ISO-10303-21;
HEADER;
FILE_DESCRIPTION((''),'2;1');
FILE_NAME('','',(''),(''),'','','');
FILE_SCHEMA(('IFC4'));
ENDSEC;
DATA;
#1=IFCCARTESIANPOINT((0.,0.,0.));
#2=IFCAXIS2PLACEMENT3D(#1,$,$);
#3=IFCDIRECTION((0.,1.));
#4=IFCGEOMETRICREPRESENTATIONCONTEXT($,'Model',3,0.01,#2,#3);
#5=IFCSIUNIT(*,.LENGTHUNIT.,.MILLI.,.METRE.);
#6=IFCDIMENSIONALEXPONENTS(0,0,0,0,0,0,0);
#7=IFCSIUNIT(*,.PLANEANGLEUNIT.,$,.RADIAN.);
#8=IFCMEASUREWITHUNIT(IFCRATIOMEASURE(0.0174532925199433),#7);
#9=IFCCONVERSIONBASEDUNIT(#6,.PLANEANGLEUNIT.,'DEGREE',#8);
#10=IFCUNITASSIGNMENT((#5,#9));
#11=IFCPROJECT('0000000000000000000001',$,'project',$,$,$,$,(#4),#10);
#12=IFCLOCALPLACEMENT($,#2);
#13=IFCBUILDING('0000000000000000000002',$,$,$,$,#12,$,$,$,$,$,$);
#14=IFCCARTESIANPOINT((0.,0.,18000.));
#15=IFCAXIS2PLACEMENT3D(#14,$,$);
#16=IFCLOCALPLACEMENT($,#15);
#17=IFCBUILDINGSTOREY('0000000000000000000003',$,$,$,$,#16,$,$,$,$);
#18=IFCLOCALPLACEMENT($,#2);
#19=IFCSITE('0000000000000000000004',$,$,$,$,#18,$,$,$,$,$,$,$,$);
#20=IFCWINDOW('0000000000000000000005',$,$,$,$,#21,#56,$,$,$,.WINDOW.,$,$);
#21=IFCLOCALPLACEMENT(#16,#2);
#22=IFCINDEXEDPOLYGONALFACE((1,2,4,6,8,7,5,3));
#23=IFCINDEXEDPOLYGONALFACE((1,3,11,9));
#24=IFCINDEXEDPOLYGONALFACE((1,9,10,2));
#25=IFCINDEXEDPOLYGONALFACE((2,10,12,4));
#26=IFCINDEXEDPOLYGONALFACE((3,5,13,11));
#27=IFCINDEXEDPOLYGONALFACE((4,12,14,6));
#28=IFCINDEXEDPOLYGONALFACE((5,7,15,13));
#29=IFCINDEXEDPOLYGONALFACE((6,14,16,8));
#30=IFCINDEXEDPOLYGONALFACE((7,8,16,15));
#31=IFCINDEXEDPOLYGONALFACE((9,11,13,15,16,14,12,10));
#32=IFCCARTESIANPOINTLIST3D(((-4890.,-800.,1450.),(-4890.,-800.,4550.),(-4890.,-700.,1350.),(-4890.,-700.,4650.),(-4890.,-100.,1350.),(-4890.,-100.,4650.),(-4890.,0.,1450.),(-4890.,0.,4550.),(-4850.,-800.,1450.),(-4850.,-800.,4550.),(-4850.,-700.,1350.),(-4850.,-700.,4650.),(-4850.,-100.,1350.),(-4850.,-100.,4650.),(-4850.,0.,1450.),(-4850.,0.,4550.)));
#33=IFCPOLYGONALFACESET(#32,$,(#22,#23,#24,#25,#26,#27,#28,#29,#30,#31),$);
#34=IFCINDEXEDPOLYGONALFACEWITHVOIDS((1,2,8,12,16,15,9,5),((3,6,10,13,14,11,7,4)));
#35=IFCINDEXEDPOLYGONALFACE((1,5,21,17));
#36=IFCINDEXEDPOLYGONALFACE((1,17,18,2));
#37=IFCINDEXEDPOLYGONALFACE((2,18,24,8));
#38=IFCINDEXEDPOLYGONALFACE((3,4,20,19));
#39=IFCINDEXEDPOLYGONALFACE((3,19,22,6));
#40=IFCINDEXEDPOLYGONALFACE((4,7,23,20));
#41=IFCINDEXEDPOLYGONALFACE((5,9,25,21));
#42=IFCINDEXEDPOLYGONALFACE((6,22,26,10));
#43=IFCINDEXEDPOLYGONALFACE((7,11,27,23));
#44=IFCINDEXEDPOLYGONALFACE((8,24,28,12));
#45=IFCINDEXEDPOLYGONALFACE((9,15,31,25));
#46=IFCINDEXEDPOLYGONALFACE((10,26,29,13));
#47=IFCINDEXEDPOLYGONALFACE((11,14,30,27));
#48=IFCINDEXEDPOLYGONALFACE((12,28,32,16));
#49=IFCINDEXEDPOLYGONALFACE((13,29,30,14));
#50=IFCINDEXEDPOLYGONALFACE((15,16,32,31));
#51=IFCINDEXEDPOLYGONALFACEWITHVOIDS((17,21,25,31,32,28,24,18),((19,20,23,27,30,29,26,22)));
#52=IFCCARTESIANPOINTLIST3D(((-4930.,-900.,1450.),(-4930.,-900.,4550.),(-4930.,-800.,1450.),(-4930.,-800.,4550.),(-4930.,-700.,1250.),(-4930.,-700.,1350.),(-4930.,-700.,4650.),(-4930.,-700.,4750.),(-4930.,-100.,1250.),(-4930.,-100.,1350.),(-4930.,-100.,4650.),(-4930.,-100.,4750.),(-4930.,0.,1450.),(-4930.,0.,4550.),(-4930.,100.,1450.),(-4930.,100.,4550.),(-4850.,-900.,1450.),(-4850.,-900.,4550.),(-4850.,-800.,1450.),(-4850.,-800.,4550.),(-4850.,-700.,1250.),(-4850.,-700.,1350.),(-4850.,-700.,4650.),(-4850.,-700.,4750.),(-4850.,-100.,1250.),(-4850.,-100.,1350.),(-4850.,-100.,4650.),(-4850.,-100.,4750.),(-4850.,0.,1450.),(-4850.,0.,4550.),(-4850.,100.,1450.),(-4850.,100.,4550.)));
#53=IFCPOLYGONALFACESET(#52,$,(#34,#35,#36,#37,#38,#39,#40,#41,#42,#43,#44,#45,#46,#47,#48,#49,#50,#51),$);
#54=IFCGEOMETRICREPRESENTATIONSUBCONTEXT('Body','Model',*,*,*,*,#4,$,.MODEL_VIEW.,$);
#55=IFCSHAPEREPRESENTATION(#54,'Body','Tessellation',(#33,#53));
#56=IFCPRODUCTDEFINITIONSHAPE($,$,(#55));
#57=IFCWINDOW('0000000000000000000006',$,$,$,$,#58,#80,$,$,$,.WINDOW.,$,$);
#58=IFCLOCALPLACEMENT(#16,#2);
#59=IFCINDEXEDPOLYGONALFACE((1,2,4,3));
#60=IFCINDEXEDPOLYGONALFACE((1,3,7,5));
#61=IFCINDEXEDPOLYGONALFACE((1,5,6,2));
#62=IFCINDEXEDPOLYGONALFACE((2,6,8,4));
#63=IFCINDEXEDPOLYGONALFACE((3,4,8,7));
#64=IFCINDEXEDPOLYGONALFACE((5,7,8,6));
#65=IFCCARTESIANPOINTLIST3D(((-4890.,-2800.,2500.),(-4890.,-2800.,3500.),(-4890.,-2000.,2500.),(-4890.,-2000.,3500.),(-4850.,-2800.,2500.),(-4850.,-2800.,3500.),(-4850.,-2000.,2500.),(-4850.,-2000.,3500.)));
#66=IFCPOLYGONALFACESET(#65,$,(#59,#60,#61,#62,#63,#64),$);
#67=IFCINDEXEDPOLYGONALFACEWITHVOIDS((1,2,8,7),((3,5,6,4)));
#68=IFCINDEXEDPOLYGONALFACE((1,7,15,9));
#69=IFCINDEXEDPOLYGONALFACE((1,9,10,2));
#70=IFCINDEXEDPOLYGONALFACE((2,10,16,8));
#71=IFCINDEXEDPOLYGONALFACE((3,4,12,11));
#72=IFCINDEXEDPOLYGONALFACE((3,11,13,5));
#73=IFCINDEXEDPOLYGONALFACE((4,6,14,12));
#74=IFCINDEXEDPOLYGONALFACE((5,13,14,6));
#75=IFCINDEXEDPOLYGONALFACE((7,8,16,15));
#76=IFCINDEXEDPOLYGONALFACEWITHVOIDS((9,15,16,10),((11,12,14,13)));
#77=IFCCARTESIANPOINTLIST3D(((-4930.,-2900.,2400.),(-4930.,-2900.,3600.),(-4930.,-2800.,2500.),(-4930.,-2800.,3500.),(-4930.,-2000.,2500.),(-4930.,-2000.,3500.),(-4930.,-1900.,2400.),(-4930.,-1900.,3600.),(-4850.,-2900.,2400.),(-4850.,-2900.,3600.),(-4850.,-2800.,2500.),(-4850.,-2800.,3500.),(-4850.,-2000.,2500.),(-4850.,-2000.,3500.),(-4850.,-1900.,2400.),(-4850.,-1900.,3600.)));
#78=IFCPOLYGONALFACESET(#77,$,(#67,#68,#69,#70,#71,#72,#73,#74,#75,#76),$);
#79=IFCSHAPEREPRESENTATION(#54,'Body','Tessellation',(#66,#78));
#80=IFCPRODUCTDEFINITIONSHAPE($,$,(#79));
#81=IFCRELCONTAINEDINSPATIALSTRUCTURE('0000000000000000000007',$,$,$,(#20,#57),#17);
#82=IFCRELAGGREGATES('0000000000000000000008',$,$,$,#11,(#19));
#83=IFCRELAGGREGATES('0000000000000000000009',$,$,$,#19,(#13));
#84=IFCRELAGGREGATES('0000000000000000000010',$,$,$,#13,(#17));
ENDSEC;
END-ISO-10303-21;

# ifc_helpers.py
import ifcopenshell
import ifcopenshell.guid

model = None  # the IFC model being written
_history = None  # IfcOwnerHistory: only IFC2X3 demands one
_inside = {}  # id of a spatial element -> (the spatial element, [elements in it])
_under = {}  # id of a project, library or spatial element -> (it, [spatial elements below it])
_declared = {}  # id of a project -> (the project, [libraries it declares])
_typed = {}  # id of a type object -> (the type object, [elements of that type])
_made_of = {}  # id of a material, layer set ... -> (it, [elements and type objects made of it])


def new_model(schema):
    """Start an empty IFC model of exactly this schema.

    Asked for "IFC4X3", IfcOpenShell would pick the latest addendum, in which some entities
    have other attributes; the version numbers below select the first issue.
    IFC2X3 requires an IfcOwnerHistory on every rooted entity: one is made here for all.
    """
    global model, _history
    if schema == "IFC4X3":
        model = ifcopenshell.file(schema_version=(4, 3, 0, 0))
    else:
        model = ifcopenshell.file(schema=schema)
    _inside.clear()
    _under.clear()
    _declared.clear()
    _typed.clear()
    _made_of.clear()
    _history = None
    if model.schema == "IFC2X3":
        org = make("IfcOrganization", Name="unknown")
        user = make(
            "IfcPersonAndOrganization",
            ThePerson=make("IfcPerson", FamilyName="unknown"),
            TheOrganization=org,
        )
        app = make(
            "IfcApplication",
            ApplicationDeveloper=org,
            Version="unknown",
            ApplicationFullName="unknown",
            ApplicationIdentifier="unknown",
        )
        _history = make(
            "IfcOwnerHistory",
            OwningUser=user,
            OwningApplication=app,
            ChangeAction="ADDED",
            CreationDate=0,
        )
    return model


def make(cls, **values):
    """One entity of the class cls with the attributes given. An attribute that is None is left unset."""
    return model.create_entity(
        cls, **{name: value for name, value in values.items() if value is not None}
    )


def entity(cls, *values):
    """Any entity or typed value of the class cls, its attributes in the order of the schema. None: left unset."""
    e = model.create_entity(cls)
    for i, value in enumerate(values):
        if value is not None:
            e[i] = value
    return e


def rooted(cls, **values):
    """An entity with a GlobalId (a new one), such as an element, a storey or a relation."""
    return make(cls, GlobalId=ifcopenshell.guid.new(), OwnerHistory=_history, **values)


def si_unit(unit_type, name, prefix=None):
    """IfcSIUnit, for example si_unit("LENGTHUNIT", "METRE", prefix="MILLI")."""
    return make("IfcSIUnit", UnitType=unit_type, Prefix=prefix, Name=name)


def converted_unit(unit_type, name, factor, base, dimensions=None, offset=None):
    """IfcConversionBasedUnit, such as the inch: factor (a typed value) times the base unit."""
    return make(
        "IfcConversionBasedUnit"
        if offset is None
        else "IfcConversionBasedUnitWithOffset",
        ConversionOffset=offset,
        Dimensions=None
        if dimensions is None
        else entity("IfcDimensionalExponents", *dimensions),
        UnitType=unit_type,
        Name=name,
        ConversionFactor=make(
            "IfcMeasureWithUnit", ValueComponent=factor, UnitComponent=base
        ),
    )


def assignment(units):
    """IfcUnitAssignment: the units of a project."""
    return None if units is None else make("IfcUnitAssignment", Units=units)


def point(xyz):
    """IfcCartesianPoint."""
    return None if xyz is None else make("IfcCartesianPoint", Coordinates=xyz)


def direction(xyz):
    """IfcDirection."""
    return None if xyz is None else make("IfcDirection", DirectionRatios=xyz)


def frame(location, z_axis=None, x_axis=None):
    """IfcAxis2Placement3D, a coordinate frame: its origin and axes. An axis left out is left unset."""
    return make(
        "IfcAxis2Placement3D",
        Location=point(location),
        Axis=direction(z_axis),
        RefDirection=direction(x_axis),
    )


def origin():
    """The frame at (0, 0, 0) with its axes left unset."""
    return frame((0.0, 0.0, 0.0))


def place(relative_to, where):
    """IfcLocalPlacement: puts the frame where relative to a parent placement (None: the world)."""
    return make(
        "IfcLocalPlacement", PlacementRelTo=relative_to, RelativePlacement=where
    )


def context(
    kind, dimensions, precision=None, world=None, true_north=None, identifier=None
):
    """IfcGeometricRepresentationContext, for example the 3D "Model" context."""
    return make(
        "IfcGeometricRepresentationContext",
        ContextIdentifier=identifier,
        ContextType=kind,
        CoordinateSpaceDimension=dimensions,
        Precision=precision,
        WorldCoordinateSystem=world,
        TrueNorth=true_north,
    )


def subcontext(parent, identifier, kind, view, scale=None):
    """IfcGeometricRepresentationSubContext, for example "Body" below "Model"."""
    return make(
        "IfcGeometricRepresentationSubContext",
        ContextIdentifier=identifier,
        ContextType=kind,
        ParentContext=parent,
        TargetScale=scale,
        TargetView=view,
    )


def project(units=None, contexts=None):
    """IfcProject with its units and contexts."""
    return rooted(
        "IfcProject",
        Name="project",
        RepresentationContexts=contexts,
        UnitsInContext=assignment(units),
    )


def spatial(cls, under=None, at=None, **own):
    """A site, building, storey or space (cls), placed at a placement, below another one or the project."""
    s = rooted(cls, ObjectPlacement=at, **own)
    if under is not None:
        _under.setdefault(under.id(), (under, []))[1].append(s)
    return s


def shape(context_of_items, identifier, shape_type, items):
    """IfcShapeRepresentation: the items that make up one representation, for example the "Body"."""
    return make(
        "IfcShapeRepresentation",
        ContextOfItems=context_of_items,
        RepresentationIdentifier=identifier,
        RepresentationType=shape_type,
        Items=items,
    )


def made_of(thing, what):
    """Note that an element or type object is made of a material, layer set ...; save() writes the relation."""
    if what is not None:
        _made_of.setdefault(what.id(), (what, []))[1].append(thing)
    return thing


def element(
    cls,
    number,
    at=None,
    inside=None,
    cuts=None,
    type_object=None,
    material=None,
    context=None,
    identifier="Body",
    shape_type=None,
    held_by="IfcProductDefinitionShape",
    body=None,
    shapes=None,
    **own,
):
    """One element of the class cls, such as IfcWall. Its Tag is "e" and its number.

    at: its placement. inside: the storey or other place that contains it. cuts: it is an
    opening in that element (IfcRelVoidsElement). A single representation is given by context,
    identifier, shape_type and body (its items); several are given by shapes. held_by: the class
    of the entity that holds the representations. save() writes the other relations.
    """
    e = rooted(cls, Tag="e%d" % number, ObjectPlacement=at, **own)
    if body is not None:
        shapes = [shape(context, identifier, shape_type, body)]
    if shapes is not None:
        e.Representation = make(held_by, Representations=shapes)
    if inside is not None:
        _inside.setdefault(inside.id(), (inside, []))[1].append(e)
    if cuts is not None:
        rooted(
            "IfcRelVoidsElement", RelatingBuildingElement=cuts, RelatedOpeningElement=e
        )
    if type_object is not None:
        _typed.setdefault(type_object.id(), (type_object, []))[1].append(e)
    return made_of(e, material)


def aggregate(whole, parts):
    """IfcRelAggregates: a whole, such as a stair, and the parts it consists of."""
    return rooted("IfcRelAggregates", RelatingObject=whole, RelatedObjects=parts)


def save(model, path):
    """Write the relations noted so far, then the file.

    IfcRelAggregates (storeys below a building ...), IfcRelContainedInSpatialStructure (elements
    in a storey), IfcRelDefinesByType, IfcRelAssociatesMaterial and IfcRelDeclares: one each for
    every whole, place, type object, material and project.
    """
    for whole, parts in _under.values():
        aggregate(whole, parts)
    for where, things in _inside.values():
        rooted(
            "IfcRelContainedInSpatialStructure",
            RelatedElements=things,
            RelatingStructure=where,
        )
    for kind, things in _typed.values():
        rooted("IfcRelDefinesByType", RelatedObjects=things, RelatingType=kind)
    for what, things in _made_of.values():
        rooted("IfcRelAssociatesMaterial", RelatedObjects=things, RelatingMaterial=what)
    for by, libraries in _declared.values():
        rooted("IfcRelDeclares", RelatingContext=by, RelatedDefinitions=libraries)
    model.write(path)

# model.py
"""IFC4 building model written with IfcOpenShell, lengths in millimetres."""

from ifc_helpers import new_model, entity, si_unit, converted_unit, direction, frame, origin, place, context, subcontext, project, spatial, element, save


model = new_model("IFC4")

# Units and contexts
model_context = context("Model", 3, precision=0.01, world=origin(), true_north=direction((0.0, 1.0)))
body_context = subcontext(model_context, "Body", "Model", "MODEL_VIEW")
ifc_project = project(units=[si_unit("LENGTHUNIT", "METRE", prefix="MILLI"), converted_unit("PLANEANGLEUNIT", "DEGREE", entity("IfcRatioMeasure", 0.0174532925199433), si_unit("PLANEANGLEUNIT", "RADIAN"), dimensions=[0, 0, 0, 0, 0, 0, 0])], contexts=[model_context])

# Site, building, storey
site_placement = place(None, origin())
site = spatial("IfcSite", under=ifc_project, at=site_placement)
building_placement = place(None, origin())
building = spatial("IfcBuilding", under=site, at=building_placement)
storey_placement = place(None, frame((0.0, 0.0, 18000.0)))
storey = spatial("IfcBuildingStorey", under=building, at=storey_placement)

# Shared definitions
cartesian_point_1 = entity("IfcCartesianPoint", [-400.0, -1550.0])
shared_polyline_1 = entity("IfcPolyline", [cartesian_point_1, entity("IfcCartesianPoint", [-400.0, 1550.0]), entity("IfcCartesianPoint", [-300.0, 1650.0]), entity("IfcCartesianPoint", [300.0, 1650.0]), entity("IfcCartesianPoint", [400.0, 1550.0]), entity("IfcCartesianPoint", [400.0, -1550.0]), entity("IfcCartesianPoint", [300.0, -1650.0]), entity("IfcCartesianPoint", [-300.0, -1650.0]), cartesian_point_1])
cartesian_point_2 = entity("IfcCartesianPoint", [-400.0, -500.0])
shared_polyline_2 = entity("IfcPolyline", [cartesian_point_2, entity("IfcCartesianPoint", [-400.0, 500.0]), entity("IfcCartesianPoint", [-400.0, 500.0]), entity("IfcCartesianPoint", [400.0, 500.0]), entity("IfcCartesianPoint", [400.0, 500.0]), entity("IfcCartesianPoint", [400.0, -500.0]), entity("IfcCartesianPoint", [400.0, -500.0]), entity("IfcCartesianPoint", [-400.0, -500.0]), cartesian_point_2])

# Shared definitions
wall_1_placement = place(storey_placement, frame((-4900.0, 100.0, 0.0), z_axis=(0.0, 0.0, 1.0), x_axis=(0.0, -1.0, 0.0)))
window_1_placement = place(wall_1_placement, frame((500.0, 50.0, 3000.0)))
window_2_placement = place(wall_1_placement, frame((2500.0, 50.0, 3000.0)))

# Windows
cartesian_point_3 = entity("IfcCartesianPoint", [-500.0, -1550.0])
element("IfcWindow", 1, at=window_1_placement, inside=storey, PredefinedType="WINDOW", context=body_context, shape_type="SweptSolid", body=[
    entity("IfcExtrudedAreaSolid", entity("IfcArbitraryClosedProfileDef", "AREA", None, shared_polyline_1), entity("IfcAxis2Placement3D", entity("IfcCartesianPoint", [0.0, 0.0, 0.0]), entity("IfcDirection", [0.0, -1.0, 0.0]), entity("IfcDirection", [1.0, 0.0, 0.0])), entity("IfcDirection", [0.0, 0.0, 1.0]), 40.0),
    entity("IfcExtrudedAreaSolid", entity("IfcArbitraryProfileDefWithVoids", "AREA", None, entity("IfcPolyline", [cartesian_point_3, entity("IfcCartesianPoint", [-500.0, 1550.0]), entity("IfcCartesianPoint", [-300.0, 1750.0]), entity("IfcCartesianPoint", [300.0, 1750.0]), entity("IfcCartesianPoint", [500.0, 1550.0]), entity("IfcCartesianPoint", [500.0, -1550.0]), entity("IfcCartesianPoint", [300.0, -1750.0]), entity("IfcCartesianPoint", [-300.0, -1750.0]), cartesian_point_3]), [shared_polyline_1]), entity("IfcAxis2Placement3D", entity("IfcCartesianPoint", [0.0, 0.0, 0.0]), entity("IfcDirection", [0.0, -1.0, 0.0]), entity("IfcDirection", [1.0, 0.0, 0.0])), entity("IfcDirection", [0.0, 0.0, 1.0]), 80.0),
])
cartesian_point_4 = entity("IfcCartesianPoint", [-500.0, -600.0])
element("IfcWindow", 2, at=window_2_placement, inside=storey, PredefinedType="WINDOW", context=body_context, shape_type="SweptSolid", body=[
    entity("IfcExtrudedAreaSolid", entity("IfcArbitraryClosedProfileDef", "AREA", None, shared_polyline_2), entity("IfcAxis2Placement3D", entity("IfcCartesianPoint", [0.0, 0.0, 0.0]), entity("IfcDirection", [0.0, -1.0, 0.0]), entity("IfcDirection", [1.0, 0.0, 0.0])), entity("IfcDirection", [0.0, 0.0, 1.0]), 40.0),
    entity("IfcExtrudedAreaSolid", entity("IfcArbitraryProfileDefWithVoids", "AREA", None, entity("IfcPolyline", [cartesian_point_4, entity("IfcCartesianPoint", [-500.0, 600.0]), entity("IfcCartesianPoint", [-500.0, 600.0]), entity("IfcCartesianPoint", [500.0, 600.0]), entity("IfcCartesianPoint", [500.0, 600.0]), entity("IfcCartesianPoint", [500.0, -600.0]), entity("IfcCartesianPoint", [500.0, -600.0]), entity("IfcCartesianPoint", [-500.0, -600.0]), cartesian_point_4]), [shared_polyline_2]), entity("IfcAxis2Placement3D", entity("IfcCartesianPoint", [0.0, 0.0, 0.0]), entity("IfcDirection", [0.0, -1.0, 0.0]), entity("IfcDirection", [1.0, 0.0, 0.0])), entity("IfcDirection", [0.0, 0.0, 1.0]), 80.0),
])

save(model, "model.ifc")
